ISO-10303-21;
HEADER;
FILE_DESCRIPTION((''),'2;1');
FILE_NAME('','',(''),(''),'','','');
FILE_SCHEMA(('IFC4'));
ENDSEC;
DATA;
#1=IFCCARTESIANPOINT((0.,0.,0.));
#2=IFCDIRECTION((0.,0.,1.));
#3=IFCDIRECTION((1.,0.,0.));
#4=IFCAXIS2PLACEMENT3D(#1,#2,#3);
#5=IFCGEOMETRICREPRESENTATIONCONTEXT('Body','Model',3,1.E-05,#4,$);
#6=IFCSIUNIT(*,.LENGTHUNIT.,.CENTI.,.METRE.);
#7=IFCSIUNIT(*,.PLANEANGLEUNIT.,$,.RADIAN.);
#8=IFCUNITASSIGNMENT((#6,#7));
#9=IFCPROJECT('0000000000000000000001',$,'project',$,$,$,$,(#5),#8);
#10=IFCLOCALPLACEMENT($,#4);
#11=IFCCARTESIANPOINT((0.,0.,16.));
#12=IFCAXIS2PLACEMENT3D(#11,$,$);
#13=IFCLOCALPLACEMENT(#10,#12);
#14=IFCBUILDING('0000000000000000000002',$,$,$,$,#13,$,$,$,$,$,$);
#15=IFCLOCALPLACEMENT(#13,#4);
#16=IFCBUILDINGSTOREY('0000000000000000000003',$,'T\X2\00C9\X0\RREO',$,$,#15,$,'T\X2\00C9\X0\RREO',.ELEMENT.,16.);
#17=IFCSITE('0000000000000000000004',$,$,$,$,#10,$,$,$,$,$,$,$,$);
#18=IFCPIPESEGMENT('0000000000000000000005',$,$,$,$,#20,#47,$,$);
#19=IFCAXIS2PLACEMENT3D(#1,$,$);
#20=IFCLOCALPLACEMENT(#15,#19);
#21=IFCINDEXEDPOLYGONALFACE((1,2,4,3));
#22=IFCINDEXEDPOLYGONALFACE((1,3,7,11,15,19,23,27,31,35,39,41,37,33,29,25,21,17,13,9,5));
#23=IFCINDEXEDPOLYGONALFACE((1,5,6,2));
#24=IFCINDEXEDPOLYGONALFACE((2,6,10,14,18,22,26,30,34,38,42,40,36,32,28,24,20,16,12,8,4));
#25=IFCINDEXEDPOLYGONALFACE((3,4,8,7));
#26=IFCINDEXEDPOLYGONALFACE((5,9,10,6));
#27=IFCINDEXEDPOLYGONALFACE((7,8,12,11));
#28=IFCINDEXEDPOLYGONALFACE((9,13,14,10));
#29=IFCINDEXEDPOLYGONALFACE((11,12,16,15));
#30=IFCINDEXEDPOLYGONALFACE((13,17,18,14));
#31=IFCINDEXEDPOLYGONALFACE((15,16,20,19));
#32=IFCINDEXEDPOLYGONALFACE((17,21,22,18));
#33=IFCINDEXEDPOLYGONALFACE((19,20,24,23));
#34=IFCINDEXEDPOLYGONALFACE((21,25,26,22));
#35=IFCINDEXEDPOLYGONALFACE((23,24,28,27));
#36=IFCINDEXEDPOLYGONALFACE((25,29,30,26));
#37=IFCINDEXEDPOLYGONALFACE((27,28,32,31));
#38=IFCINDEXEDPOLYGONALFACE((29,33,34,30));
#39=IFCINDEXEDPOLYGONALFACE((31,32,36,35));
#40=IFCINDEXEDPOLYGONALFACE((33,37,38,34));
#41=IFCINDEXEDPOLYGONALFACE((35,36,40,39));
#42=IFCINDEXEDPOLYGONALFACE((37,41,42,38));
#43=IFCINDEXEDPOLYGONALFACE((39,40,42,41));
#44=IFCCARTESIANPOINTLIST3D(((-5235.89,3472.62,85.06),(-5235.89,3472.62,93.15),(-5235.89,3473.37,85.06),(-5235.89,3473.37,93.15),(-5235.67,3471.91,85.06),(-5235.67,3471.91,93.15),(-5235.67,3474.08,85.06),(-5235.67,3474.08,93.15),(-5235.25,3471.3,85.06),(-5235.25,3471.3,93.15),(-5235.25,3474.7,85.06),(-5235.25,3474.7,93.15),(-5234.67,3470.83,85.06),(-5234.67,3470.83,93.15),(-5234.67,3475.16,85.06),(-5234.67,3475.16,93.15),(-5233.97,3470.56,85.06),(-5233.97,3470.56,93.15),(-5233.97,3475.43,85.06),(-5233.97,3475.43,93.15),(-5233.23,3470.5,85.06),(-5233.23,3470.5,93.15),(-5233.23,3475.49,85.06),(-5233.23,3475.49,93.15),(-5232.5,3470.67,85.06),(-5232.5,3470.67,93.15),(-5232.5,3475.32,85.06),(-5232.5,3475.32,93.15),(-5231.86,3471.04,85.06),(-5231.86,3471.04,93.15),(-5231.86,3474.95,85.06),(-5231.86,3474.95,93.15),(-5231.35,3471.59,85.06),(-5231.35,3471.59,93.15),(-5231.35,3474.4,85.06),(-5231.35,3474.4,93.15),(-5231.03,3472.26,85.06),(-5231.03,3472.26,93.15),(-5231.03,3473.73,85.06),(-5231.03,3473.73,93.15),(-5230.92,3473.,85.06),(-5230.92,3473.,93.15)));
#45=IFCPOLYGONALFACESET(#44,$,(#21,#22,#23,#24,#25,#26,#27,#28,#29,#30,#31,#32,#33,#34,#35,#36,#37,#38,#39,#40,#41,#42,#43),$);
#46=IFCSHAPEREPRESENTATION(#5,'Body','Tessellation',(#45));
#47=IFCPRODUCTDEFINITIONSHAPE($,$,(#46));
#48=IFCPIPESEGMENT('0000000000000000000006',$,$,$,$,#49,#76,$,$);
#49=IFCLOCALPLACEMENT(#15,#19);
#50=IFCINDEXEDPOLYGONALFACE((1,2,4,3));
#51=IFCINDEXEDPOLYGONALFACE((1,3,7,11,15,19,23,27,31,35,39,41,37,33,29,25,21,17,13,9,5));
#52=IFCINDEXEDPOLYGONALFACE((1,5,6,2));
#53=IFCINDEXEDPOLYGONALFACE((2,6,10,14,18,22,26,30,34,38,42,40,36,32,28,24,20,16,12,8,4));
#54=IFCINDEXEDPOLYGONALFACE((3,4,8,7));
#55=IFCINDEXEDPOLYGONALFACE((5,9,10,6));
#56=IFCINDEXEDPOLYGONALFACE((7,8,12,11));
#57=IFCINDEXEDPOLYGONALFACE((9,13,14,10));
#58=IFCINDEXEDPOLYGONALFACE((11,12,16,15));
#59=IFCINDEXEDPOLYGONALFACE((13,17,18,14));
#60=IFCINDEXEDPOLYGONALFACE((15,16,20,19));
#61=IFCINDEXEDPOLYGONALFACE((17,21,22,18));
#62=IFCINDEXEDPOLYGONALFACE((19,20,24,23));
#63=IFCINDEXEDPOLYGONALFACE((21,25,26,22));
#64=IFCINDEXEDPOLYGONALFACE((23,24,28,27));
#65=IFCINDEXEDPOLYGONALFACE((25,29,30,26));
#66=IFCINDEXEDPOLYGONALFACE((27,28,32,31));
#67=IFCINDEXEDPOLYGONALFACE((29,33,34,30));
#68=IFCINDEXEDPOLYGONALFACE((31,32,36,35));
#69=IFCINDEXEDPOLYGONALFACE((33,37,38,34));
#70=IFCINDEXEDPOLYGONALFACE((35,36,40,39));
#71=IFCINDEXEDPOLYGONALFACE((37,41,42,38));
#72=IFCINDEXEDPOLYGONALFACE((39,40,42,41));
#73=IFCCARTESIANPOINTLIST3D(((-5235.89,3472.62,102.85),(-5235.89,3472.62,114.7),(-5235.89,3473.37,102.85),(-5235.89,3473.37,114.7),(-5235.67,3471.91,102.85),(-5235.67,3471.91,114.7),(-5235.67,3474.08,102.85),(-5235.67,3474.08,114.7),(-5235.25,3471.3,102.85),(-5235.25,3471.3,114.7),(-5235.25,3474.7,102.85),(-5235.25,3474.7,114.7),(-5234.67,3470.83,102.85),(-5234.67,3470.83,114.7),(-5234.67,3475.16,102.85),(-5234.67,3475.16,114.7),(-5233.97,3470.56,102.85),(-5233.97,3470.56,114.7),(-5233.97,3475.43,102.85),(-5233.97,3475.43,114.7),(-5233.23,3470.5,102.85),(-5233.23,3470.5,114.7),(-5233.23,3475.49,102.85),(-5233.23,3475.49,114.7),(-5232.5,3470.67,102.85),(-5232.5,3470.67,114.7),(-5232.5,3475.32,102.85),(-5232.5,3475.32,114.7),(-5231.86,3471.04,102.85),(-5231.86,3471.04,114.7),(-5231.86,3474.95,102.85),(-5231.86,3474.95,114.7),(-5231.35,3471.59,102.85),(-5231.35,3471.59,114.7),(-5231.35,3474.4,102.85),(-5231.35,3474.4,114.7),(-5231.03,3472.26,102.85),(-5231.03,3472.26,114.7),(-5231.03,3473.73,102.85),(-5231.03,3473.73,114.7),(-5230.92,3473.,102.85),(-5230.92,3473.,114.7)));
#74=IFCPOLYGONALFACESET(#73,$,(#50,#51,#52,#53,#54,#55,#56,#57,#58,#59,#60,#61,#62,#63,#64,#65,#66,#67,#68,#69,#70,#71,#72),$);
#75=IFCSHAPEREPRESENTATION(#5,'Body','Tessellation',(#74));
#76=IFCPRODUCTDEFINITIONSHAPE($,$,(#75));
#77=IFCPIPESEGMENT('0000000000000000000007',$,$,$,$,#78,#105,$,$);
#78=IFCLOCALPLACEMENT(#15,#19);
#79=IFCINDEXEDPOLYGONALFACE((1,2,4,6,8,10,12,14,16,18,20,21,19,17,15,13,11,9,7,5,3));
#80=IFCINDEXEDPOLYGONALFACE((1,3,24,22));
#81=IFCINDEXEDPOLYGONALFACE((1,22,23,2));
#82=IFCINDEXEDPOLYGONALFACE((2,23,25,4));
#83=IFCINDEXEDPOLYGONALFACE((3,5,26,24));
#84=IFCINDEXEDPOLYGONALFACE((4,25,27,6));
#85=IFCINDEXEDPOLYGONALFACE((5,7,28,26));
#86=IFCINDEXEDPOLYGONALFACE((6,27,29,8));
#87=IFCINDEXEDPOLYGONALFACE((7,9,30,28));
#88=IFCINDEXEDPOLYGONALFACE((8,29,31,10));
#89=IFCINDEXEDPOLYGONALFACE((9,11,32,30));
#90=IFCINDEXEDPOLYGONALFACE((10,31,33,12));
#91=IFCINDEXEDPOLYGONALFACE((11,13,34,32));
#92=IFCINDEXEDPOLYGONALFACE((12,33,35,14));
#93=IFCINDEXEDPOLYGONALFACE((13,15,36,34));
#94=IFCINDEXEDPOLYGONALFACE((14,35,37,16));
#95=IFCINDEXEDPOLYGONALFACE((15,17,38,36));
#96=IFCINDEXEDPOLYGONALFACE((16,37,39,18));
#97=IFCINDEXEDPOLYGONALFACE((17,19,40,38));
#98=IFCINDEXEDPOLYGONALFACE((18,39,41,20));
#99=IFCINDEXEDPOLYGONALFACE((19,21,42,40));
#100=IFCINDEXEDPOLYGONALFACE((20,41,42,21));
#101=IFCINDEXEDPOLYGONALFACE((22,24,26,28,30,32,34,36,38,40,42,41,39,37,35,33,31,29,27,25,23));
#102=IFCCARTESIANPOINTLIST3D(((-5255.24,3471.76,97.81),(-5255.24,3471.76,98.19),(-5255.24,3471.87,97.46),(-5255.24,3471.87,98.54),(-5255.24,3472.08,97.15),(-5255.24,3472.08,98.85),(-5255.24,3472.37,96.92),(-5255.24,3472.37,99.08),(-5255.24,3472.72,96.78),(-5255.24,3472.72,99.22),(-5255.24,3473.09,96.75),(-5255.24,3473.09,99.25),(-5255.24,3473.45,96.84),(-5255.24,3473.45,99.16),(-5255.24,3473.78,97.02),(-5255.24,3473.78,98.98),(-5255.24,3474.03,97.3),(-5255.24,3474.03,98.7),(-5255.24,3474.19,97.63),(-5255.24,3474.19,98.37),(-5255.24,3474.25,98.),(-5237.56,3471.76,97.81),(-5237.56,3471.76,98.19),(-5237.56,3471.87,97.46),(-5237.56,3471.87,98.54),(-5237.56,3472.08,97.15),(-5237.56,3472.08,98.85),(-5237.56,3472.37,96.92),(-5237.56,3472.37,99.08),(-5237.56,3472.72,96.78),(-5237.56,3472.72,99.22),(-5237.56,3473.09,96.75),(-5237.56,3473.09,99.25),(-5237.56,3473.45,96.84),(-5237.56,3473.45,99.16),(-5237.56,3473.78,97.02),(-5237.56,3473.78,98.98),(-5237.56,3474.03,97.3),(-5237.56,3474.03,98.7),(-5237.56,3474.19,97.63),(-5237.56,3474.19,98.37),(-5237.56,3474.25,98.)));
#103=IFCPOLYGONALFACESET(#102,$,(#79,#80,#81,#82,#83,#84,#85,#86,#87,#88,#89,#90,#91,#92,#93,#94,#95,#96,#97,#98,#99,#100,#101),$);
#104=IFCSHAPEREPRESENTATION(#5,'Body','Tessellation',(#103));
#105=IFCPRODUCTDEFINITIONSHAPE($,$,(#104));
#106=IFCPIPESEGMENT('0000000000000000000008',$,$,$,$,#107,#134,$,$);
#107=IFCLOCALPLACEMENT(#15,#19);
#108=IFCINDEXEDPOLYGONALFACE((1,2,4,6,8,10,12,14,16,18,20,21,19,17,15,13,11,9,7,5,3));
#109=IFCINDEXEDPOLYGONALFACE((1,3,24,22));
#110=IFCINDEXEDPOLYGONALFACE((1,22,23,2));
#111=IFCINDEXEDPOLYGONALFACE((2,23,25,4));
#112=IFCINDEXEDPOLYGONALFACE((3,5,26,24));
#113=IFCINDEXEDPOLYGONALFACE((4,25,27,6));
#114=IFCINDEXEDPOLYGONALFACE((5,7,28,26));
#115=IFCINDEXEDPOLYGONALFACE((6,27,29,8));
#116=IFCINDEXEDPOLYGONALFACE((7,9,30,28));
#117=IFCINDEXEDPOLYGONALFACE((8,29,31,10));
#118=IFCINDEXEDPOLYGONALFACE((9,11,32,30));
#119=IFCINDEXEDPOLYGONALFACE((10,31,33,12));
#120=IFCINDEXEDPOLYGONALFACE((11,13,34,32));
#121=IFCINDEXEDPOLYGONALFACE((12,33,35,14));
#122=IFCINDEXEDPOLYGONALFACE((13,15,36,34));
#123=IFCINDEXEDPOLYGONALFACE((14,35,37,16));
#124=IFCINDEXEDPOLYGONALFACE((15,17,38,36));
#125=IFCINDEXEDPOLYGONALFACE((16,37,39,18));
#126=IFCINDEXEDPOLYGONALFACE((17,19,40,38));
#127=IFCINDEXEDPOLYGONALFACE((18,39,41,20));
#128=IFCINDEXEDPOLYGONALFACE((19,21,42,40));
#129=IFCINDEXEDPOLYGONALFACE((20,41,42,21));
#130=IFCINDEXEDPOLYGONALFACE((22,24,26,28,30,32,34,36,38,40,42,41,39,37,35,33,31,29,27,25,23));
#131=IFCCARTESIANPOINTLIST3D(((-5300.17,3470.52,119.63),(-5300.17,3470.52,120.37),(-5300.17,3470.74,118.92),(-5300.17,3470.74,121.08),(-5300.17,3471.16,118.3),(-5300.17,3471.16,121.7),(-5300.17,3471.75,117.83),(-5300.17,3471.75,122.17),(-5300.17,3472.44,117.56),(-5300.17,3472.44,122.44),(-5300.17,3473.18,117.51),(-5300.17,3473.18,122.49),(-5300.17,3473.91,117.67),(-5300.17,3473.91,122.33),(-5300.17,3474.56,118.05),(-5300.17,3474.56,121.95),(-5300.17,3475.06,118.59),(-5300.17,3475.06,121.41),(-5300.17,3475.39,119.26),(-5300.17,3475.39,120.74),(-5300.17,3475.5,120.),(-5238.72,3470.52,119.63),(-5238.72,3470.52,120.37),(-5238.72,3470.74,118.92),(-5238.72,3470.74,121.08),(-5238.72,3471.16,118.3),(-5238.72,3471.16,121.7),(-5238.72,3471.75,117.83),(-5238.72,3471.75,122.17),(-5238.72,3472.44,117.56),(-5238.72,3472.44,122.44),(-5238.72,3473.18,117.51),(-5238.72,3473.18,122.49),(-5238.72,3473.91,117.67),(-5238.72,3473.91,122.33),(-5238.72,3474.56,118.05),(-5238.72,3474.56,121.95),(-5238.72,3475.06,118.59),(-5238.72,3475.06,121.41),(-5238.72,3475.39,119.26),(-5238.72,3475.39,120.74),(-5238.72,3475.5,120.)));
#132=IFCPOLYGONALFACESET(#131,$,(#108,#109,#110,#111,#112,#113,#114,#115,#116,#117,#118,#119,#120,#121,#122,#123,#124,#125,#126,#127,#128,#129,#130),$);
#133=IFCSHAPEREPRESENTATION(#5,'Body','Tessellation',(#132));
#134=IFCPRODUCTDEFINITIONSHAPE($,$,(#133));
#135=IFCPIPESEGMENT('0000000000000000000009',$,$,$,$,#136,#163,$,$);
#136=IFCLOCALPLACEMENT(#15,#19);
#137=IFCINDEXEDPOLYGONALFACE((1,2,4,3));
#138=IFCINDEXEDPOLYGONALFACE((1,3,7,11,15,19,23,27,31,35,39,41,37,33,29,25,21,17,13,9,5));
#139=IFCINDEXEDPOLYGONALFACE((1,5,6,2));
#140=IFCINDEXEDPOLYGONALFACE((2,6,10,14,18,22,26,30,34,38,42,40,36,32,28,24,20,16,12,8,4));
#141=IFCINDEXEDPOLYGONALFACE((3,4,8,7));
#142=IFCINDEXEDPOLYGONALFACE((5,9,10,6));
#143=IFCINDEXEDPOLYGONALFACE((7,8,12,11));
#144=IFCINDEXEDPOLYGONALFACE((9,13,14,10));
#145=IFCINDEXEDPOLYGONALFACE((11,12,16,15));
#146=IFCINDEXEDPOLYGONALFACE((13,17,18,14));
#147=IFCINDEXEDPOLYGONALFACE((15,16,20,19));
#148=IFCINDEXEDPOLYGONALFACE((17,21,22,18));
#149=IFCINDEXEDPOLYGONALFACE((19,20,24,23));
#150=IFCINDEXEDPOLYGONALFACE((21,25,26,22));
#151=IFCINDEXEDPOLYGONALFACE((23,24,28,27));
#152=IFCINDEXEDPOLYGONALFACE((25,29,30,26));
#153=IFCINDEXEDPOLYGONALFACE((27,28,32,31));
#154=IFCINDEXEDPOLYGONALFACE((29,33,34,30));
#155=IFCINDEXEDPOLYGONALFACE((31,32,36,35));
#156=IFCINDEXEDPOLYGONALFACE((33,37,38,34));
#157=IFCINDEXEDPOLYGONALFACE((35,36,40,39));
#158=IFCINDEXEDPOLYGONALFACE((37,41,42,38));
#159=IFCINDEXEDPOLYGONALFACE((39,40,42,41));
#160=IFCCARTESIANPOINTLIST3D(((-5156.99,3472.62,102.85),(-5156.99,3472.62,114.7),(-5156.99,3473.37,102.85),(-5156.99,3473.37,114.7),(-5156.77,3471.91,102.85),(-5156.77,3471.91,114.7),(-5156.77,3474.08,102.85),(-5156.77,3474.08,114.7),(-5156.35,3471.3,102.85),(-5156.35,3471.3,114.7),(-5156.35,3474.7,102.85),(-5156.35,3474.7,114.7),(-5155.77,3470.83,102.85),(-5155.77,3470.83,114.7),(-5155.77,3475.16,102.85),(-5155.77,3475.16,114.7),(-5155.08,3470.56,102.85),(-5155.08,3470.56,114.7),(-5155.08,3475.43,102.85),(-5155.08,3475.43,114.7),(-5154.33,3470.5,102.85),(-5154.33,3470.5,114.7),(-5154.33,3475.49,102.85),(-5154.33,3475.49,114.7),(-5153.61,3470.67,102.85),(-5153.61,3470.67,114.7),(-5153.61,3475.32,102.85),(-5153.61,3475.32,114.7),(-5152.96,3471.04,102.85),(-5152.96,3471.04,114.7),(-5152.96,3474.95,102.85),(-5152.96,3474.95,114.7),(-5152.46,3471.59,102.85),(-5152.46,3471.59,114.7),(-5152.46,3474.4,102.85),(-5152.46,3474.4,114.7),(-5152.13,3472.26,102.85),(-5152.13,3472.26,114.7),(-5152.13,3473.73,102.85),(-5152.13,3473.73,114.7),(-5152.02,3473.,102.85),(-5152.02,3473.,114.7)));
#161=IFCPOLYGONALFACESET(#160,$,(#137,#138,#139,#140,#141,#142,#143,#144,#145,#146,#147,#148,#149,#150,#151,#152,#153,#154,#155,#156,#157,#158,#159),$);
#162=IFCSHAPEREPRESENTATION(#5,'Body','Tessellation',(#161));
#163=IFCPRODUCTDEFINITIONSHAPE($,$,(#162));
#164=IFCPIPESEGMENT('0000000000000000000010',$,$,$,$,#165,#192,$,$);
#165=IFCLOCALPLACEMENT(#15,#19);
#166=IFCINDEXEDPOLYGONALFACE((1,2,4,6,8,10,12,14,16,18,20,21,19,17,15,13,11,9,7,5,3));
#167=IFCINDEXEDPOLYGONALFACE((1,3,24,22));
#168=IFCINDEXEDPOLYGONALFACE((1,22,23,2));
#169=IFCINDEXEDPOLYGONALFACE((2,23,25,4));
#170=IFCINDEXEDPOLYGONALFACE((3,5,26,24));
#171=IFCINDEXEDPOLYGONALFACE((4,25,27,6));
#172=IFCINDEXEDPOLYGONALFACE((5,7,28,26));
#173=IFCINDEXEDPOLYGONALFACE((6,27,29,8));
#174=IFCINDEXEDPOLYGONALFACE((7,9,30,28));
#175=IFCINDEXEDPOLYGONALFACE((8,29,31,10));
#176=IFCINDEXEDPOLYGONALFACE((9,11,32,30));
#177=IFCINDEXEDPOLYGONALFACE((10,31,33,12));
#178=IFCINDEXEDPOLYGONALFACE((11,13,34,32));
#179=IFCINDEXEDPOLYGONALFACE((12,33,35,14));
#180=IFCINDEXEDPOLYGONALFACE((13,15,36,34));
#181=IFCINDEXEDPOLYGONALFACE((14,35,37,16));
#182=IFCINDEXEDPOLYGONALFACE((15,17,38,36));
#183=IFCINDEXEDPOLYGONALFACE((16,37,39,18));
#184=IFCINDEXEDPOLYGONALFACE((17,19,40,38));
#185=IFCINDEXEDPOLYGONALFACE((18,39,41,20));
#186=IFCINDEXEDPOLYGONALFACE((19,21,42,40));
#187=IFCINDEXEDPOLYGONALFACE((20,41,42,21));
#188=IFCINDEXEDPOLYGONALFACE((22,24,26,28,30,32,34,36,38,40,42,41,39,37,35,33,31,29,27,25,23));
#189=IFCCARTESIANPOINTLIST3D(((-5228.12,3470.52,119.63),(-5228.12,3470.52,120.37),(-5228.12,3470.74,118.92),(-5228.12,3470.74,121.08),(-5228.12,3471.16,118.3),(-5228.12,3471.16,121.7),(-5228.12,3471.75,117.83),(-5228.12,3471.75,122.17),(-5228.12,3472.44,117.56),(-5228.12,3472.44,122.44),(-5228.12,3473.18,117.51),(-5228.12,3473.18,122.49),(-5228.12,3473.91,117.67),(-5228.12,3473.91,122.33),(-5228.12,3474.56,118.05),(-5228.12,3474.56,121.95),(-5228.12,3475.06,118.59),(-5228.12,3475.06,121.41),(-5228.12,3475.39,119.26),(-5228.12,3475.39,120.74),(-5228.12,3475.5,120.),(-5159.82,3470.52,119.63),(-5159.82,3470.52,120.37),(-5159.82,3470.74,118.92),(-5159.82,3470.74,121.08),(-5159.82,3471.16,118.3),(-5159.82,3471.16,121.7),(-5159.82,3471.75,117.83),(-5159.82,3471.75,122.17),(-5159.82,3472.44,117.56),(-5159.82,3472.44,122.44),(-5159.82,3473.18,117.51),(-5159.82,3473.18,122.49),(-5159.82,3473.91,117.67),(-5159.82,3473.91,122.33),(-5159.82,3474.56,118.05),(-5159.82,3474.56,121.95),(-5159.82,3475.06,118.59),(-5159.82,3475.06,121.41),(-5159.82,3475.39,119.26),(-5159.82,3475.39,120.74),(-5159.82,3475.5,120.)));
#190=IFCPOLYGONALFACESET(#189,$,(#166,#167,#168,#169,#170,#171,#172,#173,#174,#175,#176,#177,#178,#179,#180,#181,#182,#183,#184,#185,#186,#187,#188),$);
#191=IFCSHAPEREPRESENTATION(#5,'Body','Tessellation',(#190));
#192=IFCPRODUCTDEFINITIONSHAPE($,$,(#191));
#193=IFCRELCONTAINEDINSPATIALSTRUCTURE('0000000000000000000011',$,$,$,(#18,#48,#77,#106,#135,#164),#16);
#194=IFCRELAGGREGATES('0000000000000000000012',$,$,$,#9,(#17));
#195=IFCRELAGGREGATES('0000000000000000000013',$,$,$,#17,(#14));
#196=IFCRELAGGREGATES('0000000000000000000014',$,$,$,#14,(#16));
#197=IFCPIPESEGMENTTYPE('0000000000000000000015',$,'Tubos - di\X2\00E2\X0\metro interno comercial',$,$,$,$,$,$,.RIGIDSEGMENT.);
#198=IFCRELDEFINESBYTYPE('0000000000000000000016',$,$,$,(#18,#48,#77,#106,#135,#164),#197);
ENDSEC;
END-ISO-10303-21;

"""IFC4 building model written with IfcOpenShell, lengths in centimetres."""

from ifc_helpers import new_model, si_unit, frame, origin_with_axes, origin_2d_with_axis, place, context, project, spatial, circle, extrude, type_object, element, save


model = new_model("IFC4")

# Units and contexts
model_context = context("Model", 3, precision=1e-05, world=origin_with_axes(), identifier="Body")
ifc_project = project(units=[si_unit("LENGTHUNIT", "METRE", prefix="CENTI"), si_unit("PLANEANGLEUNIT", "RADIAN")], contexts=[model_context])

# Site, building, storey
site_placement = place(None, origin_with_axes())
site = spatial("IfcSite", under=ifc_project, at=site_placement)
building_placement = place(site_placement, frame((0.0, 0.0, 16.0)))
building = spatial("IfcBuilding", under=site, at=building_placement)
storey_placement = place(building_placement, origin_with_axes())
storey = spatial("IfcBuildingStorey", under=building, at=storey_placement, Name="TÉRREO", LongName="TÉRREO", CompositionType="ELEMENT", Elevation=16.0)

# Pipe segments
pipe_segment_type = type_object("IfcPipeSegmentType", Name="Tubos - diâmetro interno comercial", PredefinedType="RIGIDSEGMENT")
pipe_segment_1_placement = place(storey_placement, frame((-5233.42, 3473.0, 93.15), z_axis=(0.0, 0.0, 1.0), x_axis=(1.0, 0.0, 0.0)))
element("IfcPipeSegment", 1, at=pipe_segment_1_placement, inside=storey, type_object=pipe_segment_type, context=model_context, shape_type="SolidModel", body=[
    extrude(circle(Radius=2.5, at=origin_2d_with_axis()), frame((0.0, 0.0, 0.0), z_axis=(0.0, 0.0, -1.0), x_axis=(1.0, 0.0, 0.0)), (0.0, 0.0, 1.0), 8.09),
])
pipe_segment_2_placement = place(storey_placement, frame((-5233.42, 3473.0, 114.7), z_axis=(0.0, 0.0, 1.0), x_axis=(1.0, 0.0, 0.0)))
element("IfcPipeSegment", 2, at=pipe_segment_2_placement, inside=storey, type_object=pipe_segment_type, context=model_context, shape_type="SolidModel", body=[
    extrude(circle(Radius=2.5, at=origin_2d_with_axis()), frame((0.0, 0.0, 0.0), z_axis=(0.0, 0.0, -1.0), x_axis=(1.0, 0.0, 0.0)), (0.0, 0.0, 1.0), 11.85),
])
pipe_segment_3_placement = place(storey_placement, frame((-5246.4, 3473.0, 99.25), z_axis=(0.0, 0.0, 1.0), x_axis=(1.0, 0.0, 0.0)))
element("IfcPipeSegment", 3, at=pipe_segment_3_placement, inside=storey, type_object=pipe_segment_type, context=model_context, shape_type="SolidModel", body=[
    extrude(circle(Radius=1.25, at=origin_2d_with_axis()), frame((8.84, 0.0, -1.25), z_axis=(-1.0, 0.0, 0.0), x_axis=(0.0, 1.0, 0.0)), (0.0, 0.0, 1.0), 17.68),
])
pipe_segment_4_placement = place(storey_placement, frame((-5269.44, 3473.0, 122.5), z_axis=(0.0, 0.0, 1.0), x_axis=(1.0, 0.0, 0.0)))
element("IfcPipeSegment", 4, at=pipe_segment_4_placement, inside=storey, type_object=pipe_segment_type, context=model_context, shape_type="SolidModel", body=[
    extrude(circle(Radius=2.5, at=origin_2d_with_axis()), frame((30.73, 0.0, -2.5), z_axis=(-1.0, 0.0, 0.0), x_axis=(0.0, 1.0, 0.0)), (0.0, 0.0, 1.0), 61.46),
])
pipe_segment_5_placement = place(storey_placement, frame((-5154.52, 3473.0, 114.7), z_axis=(0.0, 0.0, 1.0), x_axis=(1.0, 0.0, 0.0)))
element("IfcPipeSegment", 5, at=pipe_segment_5_placement, inside=storey, type_object=pipe_segment_type, context=model_context, shape_type="SolidModel", body=[
    extrude(circle(Radius=2.5, at=origin_2d_with_axis()), frame((0.0, 0.0, 0.0), z_axis=(0.0, 0.0, -1.0), x_axis=(1.0, 0.0, 0.0)), (0.0, 0.0, 1.0), 11.85),
])
pipe_segment_6_placement = place(storey_placement, frame((-5193.97, 3473.0, 122.5), z_axis=(0.0, 0.0, 1.0), x_axis=(1.0, 0.0, 0.0)))
element("IfcPipeSegment", 6, at=pipe_segment_6_placement, inside=storey, type_object=pipe_segment_type, context=model_context, shape_type="SolidModel", body=[
    extrude(circle(Radius=2.5, at=origin_2d_with_axis()), frame((34.15, 0.0, -2.5), z_axis=(-1.0, 0.0, 0.0), x_axis=(0.0, 1.0, 0.0)), (0.0, 0.0, 1.0), 68.29),
])

save(model, "model.ifc")
